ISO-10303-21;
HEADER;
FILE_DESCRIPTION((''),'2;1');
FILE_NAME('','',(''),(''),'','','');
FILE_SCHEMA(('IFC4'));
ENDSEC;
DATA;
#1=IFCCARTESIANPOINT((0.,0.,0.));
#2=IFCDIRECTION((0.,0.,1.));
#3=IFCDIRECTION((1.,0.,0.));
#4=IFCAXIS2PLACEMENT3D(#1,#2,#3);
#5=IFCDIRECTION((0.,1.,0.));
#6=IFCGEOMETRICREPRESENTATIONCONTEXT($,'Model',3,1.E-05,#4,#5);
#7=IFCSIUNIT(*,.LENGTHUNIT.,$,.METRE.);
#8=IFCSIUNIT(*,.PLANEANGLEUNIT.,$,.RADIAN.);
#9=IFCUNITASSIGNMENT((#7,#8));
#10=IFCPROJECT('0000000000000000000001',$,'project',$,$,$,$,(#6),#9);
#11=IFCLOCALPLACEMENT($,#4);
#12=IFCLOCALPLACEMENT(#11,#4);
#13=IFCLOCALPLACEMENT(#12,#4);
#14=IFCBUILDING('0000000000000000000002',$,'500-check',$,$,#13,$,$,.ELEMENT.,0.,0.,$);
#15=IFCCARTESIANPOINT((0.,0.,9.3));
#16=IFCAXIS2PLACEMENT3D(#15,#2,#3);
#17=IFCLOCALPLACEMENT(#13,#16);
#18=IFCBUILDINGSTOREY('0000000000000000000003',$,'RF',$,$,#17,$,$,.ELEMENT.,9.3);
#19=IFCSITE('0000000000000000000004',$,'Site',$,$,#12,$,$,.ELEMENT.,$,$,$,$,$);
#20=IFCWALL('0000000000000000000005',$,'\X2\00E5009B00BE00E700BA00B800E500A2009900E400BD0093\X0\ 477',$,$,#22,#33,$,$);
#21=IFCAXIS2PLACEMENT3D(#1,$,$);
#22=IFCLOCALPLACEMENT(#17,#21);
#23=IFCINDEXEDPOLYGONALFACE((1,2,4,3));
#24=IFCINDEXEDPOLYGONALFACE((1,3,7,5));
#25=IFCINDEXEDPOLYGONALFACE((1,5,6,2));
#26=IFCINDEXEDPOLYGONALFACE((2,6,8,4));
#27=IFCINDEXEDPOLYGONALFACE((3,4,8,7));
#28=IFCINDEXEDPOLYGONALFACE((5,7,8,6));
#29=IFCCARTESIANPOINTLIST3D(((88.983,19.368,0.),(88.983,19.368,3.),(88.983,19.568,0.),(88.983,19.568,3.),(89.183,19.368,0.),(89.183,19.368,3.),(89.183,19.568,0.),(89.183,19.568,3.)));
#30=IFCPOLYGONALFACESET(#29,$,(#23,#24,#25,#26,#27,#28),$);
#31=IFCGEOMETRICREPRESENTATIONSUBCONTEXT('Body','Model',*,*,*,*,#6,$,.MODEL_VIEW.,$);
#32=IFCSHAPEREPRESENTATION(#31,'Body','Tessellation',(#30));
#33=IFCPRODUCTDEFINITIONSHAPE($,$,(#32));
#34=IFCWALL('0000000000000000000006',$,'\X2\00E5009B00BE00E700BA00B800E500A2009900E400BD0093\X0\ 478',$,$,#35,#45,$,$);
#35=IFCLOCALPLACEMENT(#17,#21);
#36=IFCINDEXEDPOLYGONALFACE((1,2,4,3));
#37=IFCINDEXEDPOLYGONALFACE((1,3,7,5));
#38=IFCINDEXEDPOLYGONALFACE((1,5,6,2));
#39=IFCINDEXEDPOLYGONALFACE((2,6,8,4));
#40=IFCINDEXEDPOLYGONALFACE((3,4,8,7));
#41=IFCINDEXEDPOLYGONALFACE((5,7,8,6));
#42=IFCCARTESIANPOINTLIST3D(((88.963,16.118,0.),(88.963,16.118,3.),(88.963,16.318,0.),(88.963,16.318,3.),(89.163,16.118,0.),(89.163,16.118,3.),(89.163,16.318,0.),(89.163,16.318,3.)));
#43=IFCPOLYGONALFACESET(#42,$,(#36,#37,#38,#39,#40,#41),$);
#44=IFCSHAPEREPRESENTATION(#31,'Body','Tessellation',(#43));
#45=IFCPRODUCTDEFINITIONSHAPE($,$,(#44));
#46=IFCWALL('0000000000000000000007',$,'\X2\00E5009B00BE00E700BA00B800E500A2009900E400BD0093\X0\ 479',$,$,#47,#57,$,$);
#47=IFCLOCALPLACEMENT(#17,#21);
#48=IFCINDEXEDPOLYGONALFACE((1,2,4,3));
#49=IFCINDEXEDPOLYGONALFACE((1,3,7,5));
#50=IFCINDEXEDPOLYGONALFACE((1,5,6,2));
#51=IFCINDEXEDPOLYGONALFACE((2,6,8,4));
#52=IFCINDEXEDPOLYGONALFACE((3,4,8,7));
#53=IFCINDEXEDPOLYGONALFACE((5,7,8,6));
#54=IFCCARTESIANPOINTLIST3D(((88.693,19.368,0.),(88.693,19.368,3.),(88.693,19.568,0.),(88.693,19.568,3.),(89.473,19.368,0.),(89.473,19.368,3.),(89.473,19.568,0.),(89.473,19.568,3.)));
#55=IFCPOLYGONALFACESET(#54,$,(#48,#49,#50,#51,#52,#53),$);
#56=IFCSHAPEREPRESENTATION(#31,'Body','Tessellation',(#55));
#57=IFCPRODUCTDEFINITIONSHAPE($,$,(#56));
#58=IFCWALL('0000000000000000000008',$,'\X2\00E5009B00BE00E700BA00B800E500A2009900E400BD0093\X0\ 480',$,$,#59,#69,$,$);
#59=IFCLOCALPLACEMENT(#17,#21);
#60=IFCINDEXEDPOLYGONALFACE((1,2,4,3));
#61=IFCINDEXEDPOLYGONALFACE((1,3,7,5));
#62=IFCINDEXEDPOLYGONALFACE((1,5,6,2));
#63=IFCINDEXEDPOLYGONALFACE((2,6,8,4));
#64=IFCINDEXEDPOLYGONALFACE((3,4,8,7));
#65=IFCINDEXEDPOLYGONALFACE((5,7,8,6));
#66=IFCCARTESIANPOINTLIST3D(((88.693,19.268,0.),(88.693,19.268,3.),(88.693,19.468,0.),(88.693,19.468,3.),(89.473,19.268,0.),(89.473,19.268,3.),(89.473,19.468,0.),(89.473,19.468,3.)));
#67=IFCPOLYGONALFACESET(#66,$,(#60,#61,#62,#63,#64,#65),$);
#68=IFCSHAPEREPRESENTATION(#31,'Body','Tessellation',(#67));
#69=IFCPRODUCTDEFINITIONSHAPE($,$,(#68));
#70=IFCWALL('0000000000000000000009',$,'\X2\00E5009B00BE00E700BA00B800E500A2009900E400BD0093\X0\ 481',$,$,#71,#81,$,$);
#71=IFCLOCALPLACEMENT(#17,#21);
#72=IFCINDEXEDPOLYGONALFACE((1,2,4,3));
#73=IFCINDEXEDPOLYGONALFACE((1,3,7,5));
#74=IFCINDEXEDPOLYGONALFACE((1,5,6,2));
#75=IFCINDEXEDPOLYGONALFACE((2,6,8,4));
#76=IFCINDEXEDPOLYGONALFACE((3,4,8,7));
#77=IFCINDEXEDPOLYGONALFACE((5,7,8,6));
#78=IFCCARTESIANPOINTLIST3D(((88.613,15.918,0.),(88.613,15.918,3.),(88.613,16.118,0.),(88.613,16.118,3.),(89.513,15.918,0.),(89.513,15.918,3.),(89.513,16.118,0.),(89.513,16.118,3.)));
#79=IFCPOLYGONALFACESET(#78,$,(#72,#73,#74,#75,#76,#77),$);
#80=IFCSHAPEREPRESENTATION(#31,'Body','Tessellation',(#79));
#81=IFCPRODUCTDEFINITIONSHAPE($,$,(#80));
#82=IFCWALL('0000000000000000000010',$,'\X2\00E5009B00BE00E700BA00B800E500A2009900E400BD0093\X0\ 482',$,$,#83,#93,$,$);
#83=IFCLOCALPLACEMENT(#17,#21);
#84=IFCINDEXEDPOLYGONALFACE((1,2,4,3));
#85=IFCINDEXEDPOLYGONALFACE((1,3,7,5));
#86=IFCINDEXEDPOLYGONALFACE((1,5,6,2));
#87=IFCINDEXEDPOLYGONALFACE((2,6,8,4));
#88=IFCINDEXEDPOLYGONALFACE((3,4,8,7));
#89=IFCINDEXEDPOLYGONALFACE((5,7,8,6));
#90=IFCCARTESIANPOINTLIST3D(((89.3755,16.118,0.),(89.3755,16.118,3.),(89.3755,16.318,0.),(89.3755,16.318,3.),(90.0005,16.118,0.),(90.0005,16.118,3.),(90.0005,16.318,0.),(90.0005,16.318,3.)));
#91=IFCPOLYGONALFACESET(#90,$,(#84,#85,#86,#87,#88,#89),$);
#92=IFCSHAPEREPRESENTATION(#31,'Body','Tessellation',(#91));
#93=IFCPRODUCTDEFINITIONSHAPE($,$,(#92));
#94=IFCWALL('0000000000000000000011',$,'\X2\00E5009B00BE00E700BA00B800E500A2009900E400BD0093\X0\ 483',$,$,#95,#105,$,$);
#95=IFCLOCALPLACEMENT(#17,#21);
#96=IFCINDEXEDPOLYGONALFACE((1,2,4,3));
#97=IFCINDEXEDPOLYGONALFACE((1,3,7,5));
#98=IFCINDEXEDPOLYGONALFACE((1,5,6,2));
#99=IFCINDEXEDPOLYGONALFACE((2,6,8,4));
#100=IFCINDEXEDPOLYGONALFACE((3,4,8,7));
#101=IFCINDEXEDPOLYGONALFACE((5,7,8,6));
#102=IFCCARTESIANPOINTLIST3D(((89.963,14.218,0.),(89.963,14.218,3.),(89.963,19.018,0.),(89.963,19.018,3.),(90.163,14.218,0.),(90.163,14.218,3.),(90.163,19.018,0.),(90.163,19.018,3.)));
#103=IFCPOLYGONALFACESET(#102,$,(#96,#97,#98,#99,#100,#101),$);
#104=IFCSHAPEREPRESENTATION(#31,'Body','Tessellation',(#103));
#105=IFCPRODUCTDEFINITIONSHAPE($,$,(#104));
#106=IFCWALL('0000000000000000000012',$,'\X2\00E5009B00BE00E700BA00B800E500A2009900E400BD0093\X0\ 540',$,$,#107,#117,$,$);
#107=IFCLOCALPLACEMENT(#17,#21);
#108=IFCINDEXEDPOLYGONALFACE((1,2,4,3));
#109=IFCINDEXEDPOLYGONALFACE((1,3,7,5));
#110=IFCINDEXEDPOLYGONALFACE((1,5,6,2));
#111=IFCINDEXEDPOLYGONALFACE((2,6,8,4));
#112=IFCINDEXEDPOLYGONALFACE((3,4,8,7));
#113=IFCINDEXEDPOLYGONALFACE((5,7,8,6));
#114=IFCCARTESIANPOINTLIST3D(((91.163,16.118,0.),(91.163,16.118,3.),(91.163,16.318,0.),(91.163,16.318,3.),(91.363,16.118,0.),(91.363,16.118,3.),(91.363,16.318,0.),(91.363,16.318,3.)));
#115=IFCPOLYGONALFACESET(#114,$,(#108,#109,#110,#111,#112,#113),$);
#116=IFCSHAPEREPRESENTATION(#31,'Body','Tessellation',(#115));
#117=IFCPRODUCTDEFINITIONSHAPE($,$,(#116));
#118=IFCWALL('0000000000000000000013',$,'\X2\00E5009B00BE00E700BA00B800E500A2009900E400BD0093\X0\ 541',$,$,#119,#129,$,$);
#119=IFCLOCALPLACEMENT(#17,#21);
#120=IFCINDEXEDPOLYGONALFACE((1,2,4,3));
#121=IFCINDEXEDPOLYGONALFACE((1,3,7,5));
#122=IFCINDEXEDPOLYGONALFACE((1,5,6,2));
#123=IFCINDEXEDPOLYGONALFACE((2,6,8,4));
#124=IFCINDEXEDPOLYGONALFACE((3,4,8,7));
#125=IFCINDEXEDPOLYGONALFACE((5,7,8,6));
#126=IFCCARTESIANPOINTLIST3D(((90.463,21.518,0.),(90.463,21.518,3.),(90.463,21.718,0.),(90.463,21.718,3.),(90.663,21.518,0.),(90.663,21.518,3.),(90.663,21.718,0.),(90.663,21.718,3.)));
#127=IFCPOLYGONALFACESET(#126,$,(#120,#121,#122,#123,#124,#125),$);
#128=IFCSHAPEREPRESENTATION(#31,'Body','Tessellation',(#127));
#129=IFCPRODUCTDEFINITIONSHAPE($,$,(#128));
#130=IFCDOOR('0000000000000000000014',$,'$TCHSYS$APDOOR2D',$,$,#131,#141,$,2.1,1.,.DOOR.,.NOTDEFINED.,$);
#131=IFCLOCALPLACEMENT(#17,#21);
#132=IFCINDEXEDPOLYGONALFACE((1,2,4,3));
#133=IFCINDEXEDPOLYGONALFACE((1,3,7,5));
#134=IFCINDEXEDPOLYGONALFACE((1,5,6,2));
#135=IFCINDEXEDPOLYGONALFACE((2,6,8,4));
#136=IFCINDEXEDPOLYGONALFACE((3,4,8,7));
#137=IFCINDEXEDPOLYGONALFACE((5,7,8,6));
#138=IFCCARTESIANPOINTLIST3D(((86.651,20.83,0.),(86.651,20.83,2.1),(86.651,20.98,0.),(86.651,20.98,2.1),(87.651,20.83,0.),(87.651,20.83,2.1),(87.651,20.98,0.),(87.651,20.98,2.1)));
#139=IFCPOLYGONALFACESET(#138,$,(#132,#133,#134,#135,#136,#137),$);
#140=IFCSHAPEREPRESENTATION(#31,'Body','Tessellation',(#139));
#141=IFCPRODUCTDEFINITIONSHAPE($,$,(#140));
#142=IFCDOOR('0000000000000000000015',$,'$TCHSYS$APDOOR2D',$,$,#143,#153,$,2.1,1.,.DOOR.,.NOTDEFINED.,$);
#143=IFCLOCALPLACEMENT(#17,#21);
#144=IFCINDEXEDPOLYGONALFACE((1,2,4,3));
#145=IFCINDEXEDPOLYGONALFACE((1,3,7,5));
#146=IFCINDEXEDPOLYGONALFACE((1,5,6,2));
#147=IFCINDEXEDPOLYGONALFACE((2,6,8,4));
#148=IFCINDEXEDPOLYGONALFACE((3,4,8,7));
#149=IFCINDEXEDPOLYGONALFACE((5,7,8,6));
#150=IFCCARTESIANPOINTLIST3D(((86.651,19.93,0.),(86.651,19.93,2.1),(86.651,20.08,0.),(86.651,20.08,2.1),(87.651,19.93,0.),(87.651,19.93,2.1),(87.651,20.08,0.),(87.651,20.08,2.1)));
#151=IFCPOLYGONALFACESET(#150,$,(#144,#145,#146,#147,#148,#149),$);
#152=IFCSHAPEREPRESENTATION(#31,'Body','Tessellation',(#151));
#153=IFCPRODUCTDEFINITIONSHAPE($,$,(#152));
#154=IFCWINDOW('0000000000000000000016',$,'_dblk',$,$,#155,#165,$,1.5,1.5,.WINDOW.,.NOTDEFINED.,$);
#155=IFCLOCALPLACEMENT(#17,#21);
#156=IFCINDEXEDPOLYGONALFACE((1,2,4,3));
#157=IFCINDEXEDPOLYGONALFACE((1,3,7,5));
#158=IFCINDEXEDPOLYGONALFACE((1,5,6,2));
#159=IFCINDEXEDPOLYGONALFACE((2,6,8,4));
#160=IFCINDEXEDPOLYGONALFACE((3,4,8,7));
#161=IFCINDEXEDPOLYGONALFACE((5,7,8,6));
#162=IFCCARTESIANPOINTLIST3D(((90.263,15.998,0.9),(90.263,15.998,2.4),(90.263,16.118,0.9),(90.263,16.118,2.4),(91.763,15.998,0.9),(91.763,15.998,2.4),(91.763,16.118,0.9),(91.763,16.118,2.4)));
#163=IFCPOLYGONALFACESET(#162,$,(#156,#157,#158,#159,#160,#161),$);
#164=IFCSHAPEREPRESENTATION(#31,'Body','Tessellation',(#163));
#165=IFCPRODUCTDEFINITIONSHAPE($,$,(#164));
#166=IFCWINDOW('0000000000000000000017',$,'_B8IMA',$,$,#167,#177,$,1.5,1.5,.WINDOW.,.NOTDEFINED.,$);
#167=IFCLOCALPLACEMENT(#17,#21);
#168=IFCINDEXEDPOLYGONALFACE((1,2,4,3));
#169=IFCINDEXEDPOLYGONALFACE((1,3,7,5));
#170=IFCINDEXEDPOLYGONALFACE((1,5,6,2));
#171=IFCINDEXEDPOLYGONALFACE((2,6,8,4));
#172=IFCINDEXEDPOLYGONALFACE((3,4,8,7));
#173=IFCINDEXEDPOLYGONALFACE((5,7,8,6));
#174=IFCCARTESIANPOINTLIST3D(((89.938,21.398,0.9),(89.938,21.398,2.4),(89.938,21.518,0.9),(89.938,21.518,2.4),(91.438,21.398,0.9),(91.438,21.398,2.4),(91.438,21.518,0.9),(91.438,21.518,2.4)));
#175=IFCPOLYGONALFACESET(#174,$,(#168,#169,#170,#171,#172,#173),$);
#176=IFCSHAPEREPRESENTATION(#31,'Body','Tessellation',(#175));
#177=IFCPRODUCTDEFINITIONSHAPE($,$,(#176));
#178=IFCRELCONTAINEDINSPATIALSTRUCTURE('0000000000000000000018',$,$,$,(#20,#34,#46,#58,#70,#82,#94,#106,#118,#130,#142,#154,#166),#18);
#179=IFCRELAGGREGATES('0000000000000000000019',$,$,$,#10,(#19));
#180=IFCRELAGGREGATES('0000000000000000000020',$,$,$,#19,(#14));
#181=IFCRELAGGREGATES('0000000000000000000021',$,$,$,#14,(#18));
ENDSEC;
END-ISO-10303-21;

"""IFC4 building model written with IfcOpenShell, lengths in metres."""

from ifc_helpers import new_model, si_unit, direction, frame, frame_2d, origin_with_axes, place, context, subcontext, project, spatial, rectangle, extrude, element, save


model = new_model("IFC4")

# Units and contexts
model_context = context("Model", 3, precision=1e-05, world=origin_with_axes(), true_north=direction((0.0, 1.0, 0.0)))
body_context = subcontext(model_context, "Body", "Model", "MODEL_VIEW")
ifc_project = project(units=[si_unit("LENGTHUNIT", "METRE"), si_unit("PLANEANGLEUNIT", "RADIAN")], contexts=[model_context])

# Site, building, storey
placement = place(None, origin_with_axes())
site_placement = place(placement, origin_with_axes())
site = spatial("IfcSite", under=ifc_project, at=site_placement, Name="Site", CompositionType="ELEMENT")
building_placement = place(site_placement, origin_with_axes())
building = spatial("IfcBuilding", under=site, at=building_placement, Name="500-check", CompositionType="ELEMENT", ElevationOfRefHeight=0.0, ElevationOfTerrain=0.0)
storey_placement = place(building_placement, frame((0.0, 0.0, 9.3), z_axis=(0.0, 0.0, 1.0), x_axis=(1.0, 0.0, 0.0)))
storey = spatial("IfcBuildingStorey", under=building, at=storey_placement, Name="RF", CompositionType="ELEMENT", Elevation=9.3)

# Walls
for number, where, z_axis, x_axis, name in (
    (1, (89.083, 19.468, 0.0), (0.0, 0.0, 1.0), (0.0, -1.0, 0.0), "å\u009b¾çº¸å¢\u0099ä½\u0093 477"),
    (2, (89.063, 16.218, 0.0), (0.0, 0.0, 1.0), (0.0, -1.0, 0.0), "å\u009b¾çº¸å¢\u0099ä½\u0093 478"),
):
    element("IfcWall", number, at=place(storey_placement, frame(where, z_axis=z_axis, x_axis=x_axis)), inside=storey, Name=name, context=body_context, shape_type="SweptSolid", body=[
        extrude(rectangle(XDim=0.2, YDim=0.2, at=frame_2d((0.0, 0.0), x_axis=(1.0, 0.0, 0.0))), frame((0.0, 0.0, 0.0), z_axis=(0.0, 0.0, 1.0)), (0.0, 0.0, 1.0), 3.0),
    ])
for number, where, z_axis, x_axis, name in (
    (3, (89.083, 19.468, 0.0), (0.0, 0.0, 1.0), (1.0, 0.0, 0.0), "å\u009b¾çº¸å¢\u0099ä½\u0093 479"),
    (4, (89.083, 19.368, 0.0), (0.0, 0.0, 1.0), (1.0, 0.0, 0.0), "å\u009b¾çº¸å¢\u0099ä½\u0093 480"),
):
    element("IfcWall", number, at=place(storey_placement, frame(where, z_axis=z_axis, x_axis=x_axis)), inside=storey, Name=name, context=body_context, shape_type="SweptSolid", body=[
        extrude(rectangle(XDim=0.78, YDim=0.2, at=frame_2d((0.0, 0.0), x_axis=(1.0, 0.0, 0.0))), frame((0.0, 0.0, 0.0), z_axis=(0.0, 0.0, 1.0)), (0.0, 0.0, 1.0), 3.0),
    ])
wall_1_placement = place(storey_placement, frame((89.063, 16.018, 0.0), z_axis=(0.0, 0.0, 1.0), x_axis=(1.0, 0.0, 0.0)))
element("IfcWall", 5, at=wall_1_placement, inside=storey, Name="å\u009b¾çº¸å¢\u0099ä½\u0093 481", context=body_context, shape_type="SweptSolid", body=[
    extrude(rectangle(XDim=0.9, YDim=0.2, at=frame_2d((0.0, 0.0), x_axis=(1.0, 0.0, 0.0))), frame((0.0, 0.0, 0.0), z_axis=(0.0, 0.0, 1.0)), (0.0, 0.0, 1.0), 3.0),
])
wall_2_placement = place(storey_placement, frame((89.688, 16.218, 0.0), z_axis=(0.0, 0.0, 1.0), x_axis=(-1.0, 0.0, 0.0)))
element("IfcWall", 6, at=wall_2_placement, inside=storey, Name="å\u009b¾çº¸å¢\u0099ä½\u0093 482", context=body_context, shape_type="SweptSolid", body=[
    extrude(rectangle(XDim=0.625, YDim=0.2, at=frame_2d((0.0, 0.0), x_axis=(1.0, 0.0, 0.0))), frame((0.0, 0.0, 0.0), z_axis=(0.0, 0.0, 1.0)), (0.0, 0.0, 1.0), 3.0),
])
wall_3_placement = place(storey_placement, frame((90.063, 16.618, 0.0), z_axis=(0.0, 0.0, 1.0), x_axis=(0.0, 1.0, 0.0)))
element("IfcWall", 7, at=wall_3_placement, inside=storey, Name="å\u009b¾çº¸å¢\u0099ä½\u0093 483", context=body_context, shape_type="SweptSolid", body=[
    extrude(rectangle(XDim=4.8, YDim=0.2, at=frame_2d((0.0, 0.0), x_axis=(1.0, 0.0, 0.0))), frame((0.0, 0.0, 0.0), z_axis=(0.0, 0.0, 1.0)), (0.0, 0.0, 1.0), 3.0),
])
for number, where, z_axis, x_axis, name in (
    (8, (91.263, 16.218, 0.0), (0.0, 0.0, 1.0), (0.0, -1.0, 0.0), "å\u009b¾çº¸å¢\u0099ä½\u0093 540"),
    (9, (90.563, 21.618, 0.0), (0.0, 0.0, 1.0), (0.0, -1.0, 0.0), "å\u009b¾çº¸å¢\u0099ä½\u0093 541"),
):
    element("IfcWall", number, at=place(storey_placement, frame(where, z_axis=z_axis, x_axis=x_axis)), inside=storey, Name=name, context=body_context, shape_type="SweptSolid", body=[
        extrude(rectangle(XDim=0.2, YDim=0.2, at=frame_2d((0.0, 0.0), x_axis=(1.0, 0.0, 0.0))), frame((0.0, 0.0, 0.0), z_axis=(0.0, 0.0, 1.0)), (0.0, 0.0, 1.0), 3.0),
    ])

# Doors
for number, where, z_axis, x_axis, name in (
    (10, (87.151, 20.905, 0.0), (0.0, 0.0, 1.0), (1.0, 0.0, 0.0), "$TCHSYS$APDOOR2D"),
    (11, (87.151, 20.005, 0.0), (0.0, 0.0, 1.0), (1.0, 0.0, 0.0), "$TCHSYS$APDOOR2D"),
):
    element("IfcDoor", number, at=place(storey_placement, frame(where, z_axis=z_axis, x_axis=x_axis)), inside=storey, Name=name, OperationType="NOTDEFINED", OverallHeight=2.1, OverallWidth=1.0, PredefinedType="DOOR", context=body_context, shape_type="SweptSolid", body=[
        extrude(rectangle(XDim=1.0, YDim=0.15, at=frame_2d((0.0, 0.0), x_axis=(1.0, 0.0, 0.0))), frame((0.0, 0.0, 0.0), z_axis=(0.0, 0.0, 1.0)), (0.0, 0.0, 1.0), 2.1),
    ])

# Windows
for number, where, z_axis, x_axis, name in (
    (12, (91.013, 16.058, 0.9), (0.0, 0.0, 1.0), (1.0, 0.0, 0.0), "_dblk"),
    (13, (90.688, 21.458, 0.9), (0.0, 0.0, 1.0), (1.0, 0.0, 0.0), "_B8IMA"),
):
    element("IfcWindow", number, at=place(storey_placement, frame(where, z_axis=z_axis, x_axis=x_axis)), inside=storey, Name=name, OverallHeight=1.5, OverallWidth=1.5, PartitioningType="NOTDEFINED", PredefinedType="WINDOW", context=body_context, shape_type="SweptSolid", body=[
        extrude(rectangle(XDim=1.5, YDim=0.12, at=frame_2d((0.0, 0.0), x_axis=(1.0, 0.0, 0.0))), frame((0.0, 0.0, 0.0), z_axis=(0.0, 0.0, 1.0)), (0.0, 0.0, 1.0), 1.5),
    ])

save(model, "model.ifc")
